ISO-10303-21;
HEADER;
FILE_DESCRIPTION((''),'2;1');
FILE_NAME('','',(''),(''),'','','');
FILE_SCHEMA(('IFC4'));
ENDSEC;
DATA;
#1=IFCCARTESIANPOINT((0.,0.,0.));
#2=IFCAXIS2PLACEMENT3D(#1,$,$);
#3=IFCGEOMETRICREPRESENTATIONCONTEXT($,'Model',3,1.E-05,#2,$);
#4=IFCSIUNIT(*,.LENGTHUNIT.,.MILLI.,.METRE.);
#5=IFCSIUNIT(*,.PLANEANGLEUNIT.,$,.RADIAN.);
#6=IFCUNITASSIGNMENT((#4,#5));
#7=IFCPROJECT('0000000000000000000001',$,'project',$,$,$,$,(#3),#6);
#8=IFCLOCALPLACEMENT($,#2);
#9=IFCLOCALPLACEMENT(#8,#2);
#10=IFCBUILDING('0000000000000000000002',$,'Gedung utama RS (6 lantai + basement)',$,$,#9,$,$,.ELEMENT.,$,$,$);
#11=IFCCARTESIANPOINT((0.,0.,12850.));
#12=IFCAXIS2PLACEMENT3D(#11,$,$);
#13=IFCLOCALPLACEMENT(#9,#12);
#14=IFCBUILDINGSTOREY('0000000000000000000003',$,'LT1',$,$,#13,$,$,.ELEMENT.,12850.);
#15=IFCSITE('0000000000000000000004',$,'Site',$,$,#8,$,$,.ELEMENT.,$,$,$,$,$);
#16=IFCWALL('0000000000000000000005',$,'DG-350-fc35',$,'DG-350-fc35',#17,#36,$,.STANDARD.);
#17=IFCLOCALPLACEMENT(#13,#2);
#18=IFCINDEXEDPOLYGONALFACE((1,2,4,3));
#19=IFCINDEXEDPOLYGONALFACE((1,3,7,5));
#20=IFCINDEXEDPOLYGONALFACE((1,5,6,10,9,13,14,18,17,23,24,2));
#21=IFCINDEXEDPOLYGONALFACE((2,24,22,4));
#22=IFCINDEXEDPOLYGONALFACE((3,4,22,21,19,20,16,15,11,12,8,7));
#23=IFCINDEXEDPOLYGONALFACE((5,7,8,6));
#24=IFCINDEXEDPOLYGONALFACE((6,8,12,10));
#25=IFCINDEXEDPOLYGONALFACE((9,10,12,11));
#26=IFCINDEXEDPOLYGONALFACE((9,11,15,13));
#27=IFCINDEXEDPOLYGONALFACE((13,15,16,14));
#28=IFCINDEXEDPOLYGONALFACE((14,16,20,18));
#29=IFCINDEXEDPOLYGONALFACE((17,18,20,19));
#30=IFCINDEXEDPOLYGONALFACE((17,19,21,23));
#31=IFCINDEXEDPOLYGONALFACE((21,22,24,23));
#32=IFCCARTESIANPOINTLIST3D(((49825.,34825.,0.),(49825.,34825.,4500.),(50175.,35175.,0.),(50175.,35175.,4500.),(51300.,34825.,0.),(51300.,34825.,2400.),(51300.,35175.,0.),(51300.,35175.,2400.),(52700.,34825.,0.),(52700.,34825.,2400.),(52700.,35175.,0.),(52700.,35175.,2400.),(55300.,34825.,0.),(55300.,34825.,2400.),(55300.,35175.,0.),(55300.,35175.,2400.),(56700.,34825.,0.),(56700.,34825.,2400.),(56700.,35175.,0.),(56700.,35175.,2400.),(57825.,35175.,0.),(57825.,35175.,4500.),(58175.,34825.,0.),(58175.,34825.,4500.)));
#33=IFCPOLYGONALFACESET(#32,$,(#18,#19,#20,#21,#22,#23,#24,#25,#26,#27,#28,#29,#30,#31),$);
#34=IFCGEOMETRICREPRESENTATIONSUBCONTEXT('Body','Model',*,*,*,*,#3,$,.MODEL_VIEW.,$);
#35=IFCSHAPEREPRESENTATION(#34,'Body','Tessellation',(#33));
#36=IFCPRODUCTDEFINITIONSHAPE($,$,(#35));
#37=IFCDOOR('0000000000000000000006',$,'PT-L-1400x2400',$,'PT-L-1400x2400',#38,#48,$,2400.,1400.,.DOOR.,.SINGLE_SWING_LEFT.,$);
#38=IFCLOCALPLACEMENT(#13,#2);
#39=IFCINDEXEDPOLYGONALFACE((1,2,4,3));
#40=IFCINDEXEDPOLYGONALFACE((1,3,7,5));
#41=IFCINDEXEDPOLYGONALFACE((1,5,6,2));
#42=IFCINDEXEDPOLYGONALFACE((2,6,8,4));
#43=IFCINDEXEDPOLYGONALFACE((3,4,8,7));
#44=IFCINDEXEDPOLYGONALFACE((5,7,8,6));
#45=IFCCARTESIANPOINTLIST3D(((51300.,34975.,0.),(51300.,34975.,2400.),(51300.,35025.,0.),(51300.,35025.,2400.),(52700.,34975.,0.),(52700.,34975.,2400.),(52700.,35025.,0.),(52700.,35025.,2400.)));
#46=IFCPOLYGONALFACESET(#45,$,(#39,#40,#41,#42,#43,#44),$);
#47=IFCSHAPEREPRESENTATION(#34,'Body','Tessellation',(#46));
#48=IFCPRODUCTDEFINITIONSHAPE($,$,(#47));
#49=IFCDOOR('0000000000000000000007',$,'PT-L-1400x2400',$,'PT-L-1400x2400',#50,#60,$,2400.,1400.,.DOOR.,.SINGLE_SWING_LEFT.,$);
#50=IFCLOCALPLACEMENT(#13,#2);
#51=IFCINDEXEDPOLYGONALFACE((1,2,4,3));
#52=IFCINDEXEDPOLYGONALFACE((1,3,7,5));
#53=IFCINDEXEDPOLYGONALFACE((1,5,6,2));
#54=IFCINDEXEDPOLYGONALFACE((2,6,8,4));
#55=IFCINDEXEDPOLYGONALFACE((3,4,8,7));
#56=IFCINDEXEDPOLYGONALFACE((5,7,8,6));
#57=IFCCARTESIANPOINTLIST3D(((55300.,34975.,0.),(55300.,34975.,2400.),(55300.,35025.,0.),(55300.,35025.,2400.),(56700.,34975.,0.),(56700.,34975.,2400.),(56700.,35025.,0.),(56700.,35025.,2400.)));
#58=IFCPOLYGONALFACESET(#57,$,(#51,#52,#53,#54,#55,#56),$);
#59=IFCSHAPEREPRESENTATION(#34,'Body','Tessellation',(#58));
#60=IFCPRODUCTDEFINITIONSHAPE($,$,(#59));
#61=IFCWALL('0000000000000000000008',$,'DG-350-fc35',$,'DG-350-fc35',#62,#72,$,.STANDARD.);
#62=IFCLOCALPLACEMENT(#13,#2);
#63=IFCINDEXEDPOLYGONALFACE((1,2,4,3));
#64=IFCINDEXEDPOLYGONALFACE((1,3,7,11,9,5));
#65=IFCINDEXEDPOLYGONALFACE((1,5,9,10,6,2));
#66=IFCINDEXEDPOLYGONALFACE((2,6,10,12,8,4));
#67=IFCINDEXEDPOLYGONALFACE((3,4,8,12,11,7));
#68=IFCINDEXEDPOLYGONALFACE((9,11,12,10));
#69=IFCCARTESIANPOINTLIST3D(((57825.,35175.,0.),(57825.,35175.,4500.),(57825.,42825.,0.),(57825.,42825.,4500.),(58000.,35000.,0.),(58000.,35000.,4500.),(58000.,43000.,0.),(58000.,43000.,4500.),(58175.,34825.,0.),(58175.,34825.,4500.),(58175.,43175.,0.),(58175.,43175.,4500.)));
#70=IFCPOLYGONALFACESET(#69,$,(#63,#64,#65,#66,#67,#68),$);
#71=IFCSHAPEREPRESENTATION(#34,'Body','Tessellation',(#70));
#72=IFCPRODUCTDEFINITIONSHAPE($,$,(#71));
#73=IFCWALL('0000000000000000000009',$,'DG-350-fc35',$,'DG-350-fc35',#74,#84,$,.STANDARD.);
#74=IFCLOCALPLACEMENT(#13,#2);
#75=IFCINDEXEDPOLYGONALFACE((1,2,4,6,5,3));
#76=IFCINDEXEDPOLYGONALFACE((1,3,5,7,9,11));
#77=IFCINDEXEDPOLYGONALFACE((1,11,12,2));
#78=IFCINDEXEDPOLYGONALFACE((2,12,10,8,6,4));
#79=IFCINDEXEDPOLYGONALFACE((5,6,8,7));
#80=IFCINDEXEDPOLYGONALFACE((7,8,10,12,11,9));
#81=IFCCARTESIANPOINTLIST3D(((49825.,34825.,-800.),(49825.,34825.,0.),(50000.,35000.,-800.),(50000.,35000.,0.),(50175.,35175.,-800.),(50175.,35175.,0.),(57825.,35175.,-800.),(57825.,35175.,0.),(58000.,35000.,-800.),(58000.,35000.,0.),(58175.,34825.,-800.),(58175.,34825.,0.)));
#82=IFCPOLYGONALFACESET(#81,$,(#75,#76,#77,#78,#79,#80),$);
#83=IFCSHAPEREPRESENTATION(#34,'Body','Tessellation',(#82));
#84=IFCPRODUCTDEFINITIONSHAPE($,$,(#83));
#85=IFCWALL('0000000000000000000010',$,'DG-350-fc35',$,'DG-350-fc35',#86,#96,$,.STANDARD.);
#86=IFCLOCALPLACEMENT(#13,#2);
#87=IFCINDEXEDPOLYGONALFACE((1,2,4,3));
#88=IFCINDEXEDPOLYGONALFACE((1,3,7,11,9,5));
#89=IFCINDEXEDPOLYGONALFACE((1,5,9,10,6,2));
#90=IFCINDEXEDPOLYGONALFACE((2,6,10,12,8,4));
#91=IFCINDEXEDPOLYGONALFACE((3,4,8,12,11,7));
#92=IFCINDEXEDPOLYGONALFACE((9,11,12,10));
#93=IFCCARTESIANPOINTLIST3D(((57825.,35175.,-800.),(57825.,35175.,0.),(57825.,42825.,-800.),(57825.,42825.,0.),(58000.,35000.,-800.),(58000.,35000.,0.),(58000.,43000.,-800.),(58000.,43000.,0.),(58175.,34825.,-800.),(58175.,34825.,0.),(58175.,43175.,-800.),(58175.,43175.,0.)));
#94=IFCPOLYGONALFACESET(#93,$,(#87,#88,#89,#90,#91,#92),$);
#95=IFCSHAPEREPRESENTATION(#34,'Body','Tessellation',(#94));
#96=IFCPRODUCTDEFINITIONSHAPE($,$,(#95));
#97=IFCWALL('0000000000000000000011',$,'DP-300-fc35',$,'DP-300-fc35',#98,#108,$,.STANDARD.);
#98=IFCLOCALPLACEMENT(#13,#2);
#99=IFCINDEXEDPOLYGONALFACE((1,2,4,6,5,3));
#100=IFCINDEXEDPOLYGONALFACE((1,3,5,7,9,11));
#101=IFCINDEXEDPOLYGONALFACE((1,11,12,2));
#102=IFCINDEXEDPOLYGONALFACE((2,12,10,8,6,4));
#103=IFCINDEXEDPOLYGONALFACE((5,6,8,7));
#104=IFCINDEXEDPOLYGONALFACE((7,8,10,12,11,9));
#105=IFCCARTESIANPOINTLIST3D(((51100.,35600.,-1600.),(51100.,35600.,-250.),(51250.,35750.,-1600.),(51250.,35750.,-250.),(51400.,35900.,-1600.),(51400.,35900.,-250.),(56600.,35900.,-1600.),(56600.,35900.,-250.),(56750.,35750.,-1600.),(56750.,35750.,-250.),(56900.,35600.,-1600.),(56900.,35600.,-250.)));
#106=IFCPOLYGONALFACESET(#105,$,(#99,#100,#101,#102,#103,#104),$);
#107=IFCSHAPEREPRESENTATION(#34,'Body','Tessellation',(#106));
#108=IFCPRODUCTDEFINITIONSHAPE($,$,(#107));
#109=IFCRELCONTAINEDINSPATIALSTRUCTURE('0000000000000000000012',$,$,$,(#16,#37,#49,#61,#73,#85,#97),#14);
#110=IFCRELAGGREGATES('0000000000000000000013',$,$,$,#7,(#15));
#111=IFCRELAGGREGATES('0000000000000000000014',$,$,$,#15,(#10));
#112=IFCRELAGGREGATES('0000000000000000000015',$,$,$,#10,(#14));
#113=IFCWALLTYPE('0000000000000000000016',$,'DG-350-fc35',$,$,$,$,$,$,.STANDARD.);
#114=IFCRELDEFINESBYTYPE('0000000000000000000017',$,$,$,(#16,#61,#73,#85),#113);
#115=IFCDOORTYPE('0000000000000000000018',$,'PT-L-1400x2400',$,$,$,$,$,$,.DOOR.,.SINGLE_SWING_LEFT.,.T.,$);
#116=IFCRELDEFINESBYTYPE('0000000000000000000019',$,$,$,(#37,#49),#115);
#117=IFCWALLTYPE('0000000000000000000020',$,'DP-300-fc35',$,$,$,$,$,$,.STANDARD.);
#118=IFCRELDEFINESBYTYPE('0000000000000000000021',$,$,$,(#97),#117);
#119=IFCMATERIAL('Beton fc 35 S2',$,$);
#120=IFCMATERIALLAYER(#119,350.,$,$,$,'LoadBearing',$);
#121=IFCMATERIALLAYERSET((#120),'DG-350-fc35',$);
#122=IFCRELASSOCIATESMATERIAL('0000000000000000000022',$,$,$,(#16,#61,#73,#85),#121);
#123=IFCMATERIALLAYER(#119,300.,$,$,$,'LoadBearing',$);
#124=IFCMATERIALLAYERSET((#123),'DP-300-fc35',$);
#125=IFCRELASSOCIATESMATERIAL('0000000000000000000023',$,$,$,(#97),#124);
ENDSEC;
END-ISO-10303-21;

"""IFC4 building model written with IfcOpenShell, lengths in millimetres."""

from ifc_helpers import new_model, si_unit, frame, frame_2d, origin, place, context, subcontext, project, spatial, polyline, rectangle, outline, extrude, material, layer, layer_set, layer_usage, type_object, element, fill, save


model = new_model("IFC4")

# Units and contexts
model_context = context("Model", 3, precision=1e-05, world=origin())
body_context = subcontext(model_context, "Body", "Model", "MODEL_VIEW")
ifc_project = project(units=[si_unit("LENGTHUNIT", "METRE", prefix="MILLI"), si_unit("PLANEANGLEUNIT", "RADIAN")], contexts=[model_context])

# Site, building, storey
site_placement = place(None, origin())
site = spatial("IfcSite", under=ifc_project, at=site_placement, Name="Site", CompositionType="ELEMENT")
building_placement = place(site_placement, origin())
building = spatial("IfcBuilding", under=site, at=building_placement, Name="Gedung utama RS (6 lantai + basement)", CompositionType="ELEMENT")
storey_placement = place(building_placement, frame((0.0, 0.0, 12850.0)))
storey = spatial("IfcBuildingStorey", under=building, at=storey_placement, Name="LT1", CompositionType="ELEMENT", Elevation=12850.0)

# Shared definitions
ifc_material = material(Name="Beton fc 35 S2")

# Wall, openings, doors
ifc_layer_1 = layer(ifc_material, 350.0, Category="LoadBearing")
ifc_layer_set_1 = layer_set([ifc_layer_1], Name="DG-350-fc35")
ifc_layer_usage_1 = layer_usage(ifc_layer_set_1, "AXIS2", "NEGATIVE", 175.0)
wall_type_1 = type_object("IfcWallType", Name="DG-350-fc35", PredefinedType="STANDARD")
wall_1_placement = place(storey_placement, frame((50000.0, 35000.0, 0.0), z_axis=(0.0, 0.0, 1.0), x_axis=(1.0, 0.0, 0.0)))
wall_1 = element("IfcWall", 1, at=wall_1_placement, inside=storey, type_object=wall_type_1, material=ifc_layer_usage_1, Name="DG-350-fc35", ObjectType="DG-350-fc35", PredefinedType="STANDARD", context=body_context, shape_type="SweptSolid", body=[
    extrude(outline(polyline([(-175.0, -175.0), (0.0, 0.0), (175.0, 175.0), (7825.0, 175.0), (8000.0, 0.0), (8175.0, -175.0), (-175.0, -175.0)])), origin(), (0.0, 0.0, 1.0), 4500.0),
])
opening_1_placement = place(wall_1_placement, frame((1300.0, 0.0, 0.0), z_axis=(0.0, 0.0, 1.0), x_axis=(1.0, 0.0, 0.0)))
opening_1 = element("IfcOpeningElement", 2, at=opening_1_placement, cuts=wall_1, PredefinedType="OPENING", context=body_context, shape_type="SweptSolid", body=[
    extrude(rectangle(XDim=1400.0, YDim=370.0, at=frame_2d((700.0, 0.0))), origin(), (0.0, 0.0, 1.0), 2400.0),
])
opening_2_placement = place(wall_1_placement, frame((5300.0, 0.0, 0.0), z_axis=(0.0, 0.0, 1.0), x_axis=(1.0, 0.0, 0.0)))
opening_2 = element("IfcOpeningElement", 3, at=opening_2_placement, cuts=wall_1, PredefinedType="OPENING", context=body_context, shape_type="SweptSolid", body=[
    extrude(rectangle(XDim=1400.0, YDim=370.0, at=frame_2d((700.0, 0.0))), origin(), (0.0, 0.0, 1.0), 2400.0),
])
door_type = type_object("IfcDoorType", Name="PT-L-1400x2400", OperationType="SINGLE_SWING_LEFT", ParameterTakesPrecedence=True, PredefinedType="DOOR")
door_1_placement = place(opening_1_placement, origin())
door_1 = element("IfcDoor", 4, at=door_1_placement, inside=storey, type_object=door_type, Name="PT-L-1400x2400", ObjectType="PT-L-1400x2400", OperationType="SINGLE_SWING_LEFT", OverallHeight=2400.0, OverallWidth=1400.0, PredefinedType="DOOR", context=body_context, shape_type="SweptSolid", body=[
    extrude(rectangle(XDim=1400.0, YDim=50.0, at=frame_2d((700.0, 0.0))), origin(), (0.0, 0.0, 1.0), 2400.0),
])
fill(opening_1, door_1)
door_2_placement = place(opening_2_placement, origin())
door_2 = element("IfcDoor", 5, at=door_2_placement, inside=storey, type_object=door_type, Name="PT-L-1400x2400", ObjectType="PT-L-1400x2400", OperationType="SINGLE_SWING_LEFT", OverallHeight=2400.0, OverallWidth=1400.0, PredefinedType="DOOR", context=body_context, shape_type="SweptSolid", body=[
    extrude(rectangle(XDim=1400.0, YDim=50.0, at=frame_2d((700.0, 0.0))), origin(), (0.0, 0.0, 1.0), 2400.0),
])
fill(opening_2, door_2)

# Walls
wall_2_placement = place(storey_placement, frame((58000.0, 35000.0, 0.0), z_axis=(0.0, 0.0, 1.0), x_axis=(0.0, 1.0, 0.0)))
element("IfcWall", 6, at=wall_2_placement, inside=storey, type_object=wall_type_1, material=ifc_layer_usage_1, Name="DG-350-fc35", ObjectType="DG-350-fc35", PredefinedType="STANDARD", context=body_context, shape_type="SweptSolid", body=[
    extrude(outline(polyline([(-175.0, -175.0), (0.0, 0.0), (175.0, 175.0), (7825.0, 175.0), (8000.0, 0.0), (8175.0, -175.0), (-175.0, -175.0)])), origin(), (0.0, 0.0, 1.0), 4500.0),
])
for number, where, z_axis, x_axis, name in (
    (7, (50000.0, 35000.0, -800.0), (0.0, 0.0, 1.0), (1.0, 0.0, 0.0), "DG-350-fc35"),
    (8, (58000.0, 35000.0, -800.0), (0.0, 0.0, 1.0), (0.0, 1.0, 0.0), "DG-350-fc35"),
):
    element("IfcWall", number, at=place(storey_placement, frame(where, z_axis=z_axis, x_axis=x_axis)), inside=storey, type_object=wall_type_1, material=ifc_layer_usage_1, Name=name, ObjectType="DG-350-fc35", PredefinedType="STANDARD", context=body_context, shape_type="SweptSolid", body=[
        extrude(outline(polyline([(-175.0, -175.0), (0.0, 0.0), (175.0, 175.0), (7825.0, 175.0), (8000.0, 0.0), (8175.0, -175.0), (-175.0, -175.0)])), origin(), (0.0, 0.0, 1.0), 800.0),
    ])
ifc_layer_2 = layer(ifc_material, 300.0, Category="LoadBearing")
ifc_layer_set_2 = layer_set([ifc_layer_2], Name="DP-300-fc35")
ifc_layer_usage_2 = layer_usage(ifc_layer_set_2, "AXIS2", "NEGATIVE", 150.0)
wall_type_2 = type_object("IfcWallType", Name="DP-300-fc35", PredefinedType="STANDARD")
wall_3_placement = place(storey_placement, frame((51250.0, 35750.0, -1600.0), z_axis=(0.0, 0.0, 1.0), x_axis=(1.0, 0.0, 0.0)))
element("IfcWall", 9, at=wall_3_placement, inside=storey, type_object=wall_type_2, material=ifc_layer_usage_2, Name="DP-300-fc35", ObjectType="DP-300-fc35", PredefinedType="STANDARD", context=body_context, shape_type="SweptSolid", body=[
    extrude(outline(polyline([(-150.0, -150.0), (0.0, 0.0), (150.0, 150.0), (5350.0, 150.0), (5500.0, 0.0), (5650.0, -150.0), (-150.0, -150.0)])), origin(), (0.0, 0.0, 1.0), 1350.0),
])

save(model, "model.ifc")
